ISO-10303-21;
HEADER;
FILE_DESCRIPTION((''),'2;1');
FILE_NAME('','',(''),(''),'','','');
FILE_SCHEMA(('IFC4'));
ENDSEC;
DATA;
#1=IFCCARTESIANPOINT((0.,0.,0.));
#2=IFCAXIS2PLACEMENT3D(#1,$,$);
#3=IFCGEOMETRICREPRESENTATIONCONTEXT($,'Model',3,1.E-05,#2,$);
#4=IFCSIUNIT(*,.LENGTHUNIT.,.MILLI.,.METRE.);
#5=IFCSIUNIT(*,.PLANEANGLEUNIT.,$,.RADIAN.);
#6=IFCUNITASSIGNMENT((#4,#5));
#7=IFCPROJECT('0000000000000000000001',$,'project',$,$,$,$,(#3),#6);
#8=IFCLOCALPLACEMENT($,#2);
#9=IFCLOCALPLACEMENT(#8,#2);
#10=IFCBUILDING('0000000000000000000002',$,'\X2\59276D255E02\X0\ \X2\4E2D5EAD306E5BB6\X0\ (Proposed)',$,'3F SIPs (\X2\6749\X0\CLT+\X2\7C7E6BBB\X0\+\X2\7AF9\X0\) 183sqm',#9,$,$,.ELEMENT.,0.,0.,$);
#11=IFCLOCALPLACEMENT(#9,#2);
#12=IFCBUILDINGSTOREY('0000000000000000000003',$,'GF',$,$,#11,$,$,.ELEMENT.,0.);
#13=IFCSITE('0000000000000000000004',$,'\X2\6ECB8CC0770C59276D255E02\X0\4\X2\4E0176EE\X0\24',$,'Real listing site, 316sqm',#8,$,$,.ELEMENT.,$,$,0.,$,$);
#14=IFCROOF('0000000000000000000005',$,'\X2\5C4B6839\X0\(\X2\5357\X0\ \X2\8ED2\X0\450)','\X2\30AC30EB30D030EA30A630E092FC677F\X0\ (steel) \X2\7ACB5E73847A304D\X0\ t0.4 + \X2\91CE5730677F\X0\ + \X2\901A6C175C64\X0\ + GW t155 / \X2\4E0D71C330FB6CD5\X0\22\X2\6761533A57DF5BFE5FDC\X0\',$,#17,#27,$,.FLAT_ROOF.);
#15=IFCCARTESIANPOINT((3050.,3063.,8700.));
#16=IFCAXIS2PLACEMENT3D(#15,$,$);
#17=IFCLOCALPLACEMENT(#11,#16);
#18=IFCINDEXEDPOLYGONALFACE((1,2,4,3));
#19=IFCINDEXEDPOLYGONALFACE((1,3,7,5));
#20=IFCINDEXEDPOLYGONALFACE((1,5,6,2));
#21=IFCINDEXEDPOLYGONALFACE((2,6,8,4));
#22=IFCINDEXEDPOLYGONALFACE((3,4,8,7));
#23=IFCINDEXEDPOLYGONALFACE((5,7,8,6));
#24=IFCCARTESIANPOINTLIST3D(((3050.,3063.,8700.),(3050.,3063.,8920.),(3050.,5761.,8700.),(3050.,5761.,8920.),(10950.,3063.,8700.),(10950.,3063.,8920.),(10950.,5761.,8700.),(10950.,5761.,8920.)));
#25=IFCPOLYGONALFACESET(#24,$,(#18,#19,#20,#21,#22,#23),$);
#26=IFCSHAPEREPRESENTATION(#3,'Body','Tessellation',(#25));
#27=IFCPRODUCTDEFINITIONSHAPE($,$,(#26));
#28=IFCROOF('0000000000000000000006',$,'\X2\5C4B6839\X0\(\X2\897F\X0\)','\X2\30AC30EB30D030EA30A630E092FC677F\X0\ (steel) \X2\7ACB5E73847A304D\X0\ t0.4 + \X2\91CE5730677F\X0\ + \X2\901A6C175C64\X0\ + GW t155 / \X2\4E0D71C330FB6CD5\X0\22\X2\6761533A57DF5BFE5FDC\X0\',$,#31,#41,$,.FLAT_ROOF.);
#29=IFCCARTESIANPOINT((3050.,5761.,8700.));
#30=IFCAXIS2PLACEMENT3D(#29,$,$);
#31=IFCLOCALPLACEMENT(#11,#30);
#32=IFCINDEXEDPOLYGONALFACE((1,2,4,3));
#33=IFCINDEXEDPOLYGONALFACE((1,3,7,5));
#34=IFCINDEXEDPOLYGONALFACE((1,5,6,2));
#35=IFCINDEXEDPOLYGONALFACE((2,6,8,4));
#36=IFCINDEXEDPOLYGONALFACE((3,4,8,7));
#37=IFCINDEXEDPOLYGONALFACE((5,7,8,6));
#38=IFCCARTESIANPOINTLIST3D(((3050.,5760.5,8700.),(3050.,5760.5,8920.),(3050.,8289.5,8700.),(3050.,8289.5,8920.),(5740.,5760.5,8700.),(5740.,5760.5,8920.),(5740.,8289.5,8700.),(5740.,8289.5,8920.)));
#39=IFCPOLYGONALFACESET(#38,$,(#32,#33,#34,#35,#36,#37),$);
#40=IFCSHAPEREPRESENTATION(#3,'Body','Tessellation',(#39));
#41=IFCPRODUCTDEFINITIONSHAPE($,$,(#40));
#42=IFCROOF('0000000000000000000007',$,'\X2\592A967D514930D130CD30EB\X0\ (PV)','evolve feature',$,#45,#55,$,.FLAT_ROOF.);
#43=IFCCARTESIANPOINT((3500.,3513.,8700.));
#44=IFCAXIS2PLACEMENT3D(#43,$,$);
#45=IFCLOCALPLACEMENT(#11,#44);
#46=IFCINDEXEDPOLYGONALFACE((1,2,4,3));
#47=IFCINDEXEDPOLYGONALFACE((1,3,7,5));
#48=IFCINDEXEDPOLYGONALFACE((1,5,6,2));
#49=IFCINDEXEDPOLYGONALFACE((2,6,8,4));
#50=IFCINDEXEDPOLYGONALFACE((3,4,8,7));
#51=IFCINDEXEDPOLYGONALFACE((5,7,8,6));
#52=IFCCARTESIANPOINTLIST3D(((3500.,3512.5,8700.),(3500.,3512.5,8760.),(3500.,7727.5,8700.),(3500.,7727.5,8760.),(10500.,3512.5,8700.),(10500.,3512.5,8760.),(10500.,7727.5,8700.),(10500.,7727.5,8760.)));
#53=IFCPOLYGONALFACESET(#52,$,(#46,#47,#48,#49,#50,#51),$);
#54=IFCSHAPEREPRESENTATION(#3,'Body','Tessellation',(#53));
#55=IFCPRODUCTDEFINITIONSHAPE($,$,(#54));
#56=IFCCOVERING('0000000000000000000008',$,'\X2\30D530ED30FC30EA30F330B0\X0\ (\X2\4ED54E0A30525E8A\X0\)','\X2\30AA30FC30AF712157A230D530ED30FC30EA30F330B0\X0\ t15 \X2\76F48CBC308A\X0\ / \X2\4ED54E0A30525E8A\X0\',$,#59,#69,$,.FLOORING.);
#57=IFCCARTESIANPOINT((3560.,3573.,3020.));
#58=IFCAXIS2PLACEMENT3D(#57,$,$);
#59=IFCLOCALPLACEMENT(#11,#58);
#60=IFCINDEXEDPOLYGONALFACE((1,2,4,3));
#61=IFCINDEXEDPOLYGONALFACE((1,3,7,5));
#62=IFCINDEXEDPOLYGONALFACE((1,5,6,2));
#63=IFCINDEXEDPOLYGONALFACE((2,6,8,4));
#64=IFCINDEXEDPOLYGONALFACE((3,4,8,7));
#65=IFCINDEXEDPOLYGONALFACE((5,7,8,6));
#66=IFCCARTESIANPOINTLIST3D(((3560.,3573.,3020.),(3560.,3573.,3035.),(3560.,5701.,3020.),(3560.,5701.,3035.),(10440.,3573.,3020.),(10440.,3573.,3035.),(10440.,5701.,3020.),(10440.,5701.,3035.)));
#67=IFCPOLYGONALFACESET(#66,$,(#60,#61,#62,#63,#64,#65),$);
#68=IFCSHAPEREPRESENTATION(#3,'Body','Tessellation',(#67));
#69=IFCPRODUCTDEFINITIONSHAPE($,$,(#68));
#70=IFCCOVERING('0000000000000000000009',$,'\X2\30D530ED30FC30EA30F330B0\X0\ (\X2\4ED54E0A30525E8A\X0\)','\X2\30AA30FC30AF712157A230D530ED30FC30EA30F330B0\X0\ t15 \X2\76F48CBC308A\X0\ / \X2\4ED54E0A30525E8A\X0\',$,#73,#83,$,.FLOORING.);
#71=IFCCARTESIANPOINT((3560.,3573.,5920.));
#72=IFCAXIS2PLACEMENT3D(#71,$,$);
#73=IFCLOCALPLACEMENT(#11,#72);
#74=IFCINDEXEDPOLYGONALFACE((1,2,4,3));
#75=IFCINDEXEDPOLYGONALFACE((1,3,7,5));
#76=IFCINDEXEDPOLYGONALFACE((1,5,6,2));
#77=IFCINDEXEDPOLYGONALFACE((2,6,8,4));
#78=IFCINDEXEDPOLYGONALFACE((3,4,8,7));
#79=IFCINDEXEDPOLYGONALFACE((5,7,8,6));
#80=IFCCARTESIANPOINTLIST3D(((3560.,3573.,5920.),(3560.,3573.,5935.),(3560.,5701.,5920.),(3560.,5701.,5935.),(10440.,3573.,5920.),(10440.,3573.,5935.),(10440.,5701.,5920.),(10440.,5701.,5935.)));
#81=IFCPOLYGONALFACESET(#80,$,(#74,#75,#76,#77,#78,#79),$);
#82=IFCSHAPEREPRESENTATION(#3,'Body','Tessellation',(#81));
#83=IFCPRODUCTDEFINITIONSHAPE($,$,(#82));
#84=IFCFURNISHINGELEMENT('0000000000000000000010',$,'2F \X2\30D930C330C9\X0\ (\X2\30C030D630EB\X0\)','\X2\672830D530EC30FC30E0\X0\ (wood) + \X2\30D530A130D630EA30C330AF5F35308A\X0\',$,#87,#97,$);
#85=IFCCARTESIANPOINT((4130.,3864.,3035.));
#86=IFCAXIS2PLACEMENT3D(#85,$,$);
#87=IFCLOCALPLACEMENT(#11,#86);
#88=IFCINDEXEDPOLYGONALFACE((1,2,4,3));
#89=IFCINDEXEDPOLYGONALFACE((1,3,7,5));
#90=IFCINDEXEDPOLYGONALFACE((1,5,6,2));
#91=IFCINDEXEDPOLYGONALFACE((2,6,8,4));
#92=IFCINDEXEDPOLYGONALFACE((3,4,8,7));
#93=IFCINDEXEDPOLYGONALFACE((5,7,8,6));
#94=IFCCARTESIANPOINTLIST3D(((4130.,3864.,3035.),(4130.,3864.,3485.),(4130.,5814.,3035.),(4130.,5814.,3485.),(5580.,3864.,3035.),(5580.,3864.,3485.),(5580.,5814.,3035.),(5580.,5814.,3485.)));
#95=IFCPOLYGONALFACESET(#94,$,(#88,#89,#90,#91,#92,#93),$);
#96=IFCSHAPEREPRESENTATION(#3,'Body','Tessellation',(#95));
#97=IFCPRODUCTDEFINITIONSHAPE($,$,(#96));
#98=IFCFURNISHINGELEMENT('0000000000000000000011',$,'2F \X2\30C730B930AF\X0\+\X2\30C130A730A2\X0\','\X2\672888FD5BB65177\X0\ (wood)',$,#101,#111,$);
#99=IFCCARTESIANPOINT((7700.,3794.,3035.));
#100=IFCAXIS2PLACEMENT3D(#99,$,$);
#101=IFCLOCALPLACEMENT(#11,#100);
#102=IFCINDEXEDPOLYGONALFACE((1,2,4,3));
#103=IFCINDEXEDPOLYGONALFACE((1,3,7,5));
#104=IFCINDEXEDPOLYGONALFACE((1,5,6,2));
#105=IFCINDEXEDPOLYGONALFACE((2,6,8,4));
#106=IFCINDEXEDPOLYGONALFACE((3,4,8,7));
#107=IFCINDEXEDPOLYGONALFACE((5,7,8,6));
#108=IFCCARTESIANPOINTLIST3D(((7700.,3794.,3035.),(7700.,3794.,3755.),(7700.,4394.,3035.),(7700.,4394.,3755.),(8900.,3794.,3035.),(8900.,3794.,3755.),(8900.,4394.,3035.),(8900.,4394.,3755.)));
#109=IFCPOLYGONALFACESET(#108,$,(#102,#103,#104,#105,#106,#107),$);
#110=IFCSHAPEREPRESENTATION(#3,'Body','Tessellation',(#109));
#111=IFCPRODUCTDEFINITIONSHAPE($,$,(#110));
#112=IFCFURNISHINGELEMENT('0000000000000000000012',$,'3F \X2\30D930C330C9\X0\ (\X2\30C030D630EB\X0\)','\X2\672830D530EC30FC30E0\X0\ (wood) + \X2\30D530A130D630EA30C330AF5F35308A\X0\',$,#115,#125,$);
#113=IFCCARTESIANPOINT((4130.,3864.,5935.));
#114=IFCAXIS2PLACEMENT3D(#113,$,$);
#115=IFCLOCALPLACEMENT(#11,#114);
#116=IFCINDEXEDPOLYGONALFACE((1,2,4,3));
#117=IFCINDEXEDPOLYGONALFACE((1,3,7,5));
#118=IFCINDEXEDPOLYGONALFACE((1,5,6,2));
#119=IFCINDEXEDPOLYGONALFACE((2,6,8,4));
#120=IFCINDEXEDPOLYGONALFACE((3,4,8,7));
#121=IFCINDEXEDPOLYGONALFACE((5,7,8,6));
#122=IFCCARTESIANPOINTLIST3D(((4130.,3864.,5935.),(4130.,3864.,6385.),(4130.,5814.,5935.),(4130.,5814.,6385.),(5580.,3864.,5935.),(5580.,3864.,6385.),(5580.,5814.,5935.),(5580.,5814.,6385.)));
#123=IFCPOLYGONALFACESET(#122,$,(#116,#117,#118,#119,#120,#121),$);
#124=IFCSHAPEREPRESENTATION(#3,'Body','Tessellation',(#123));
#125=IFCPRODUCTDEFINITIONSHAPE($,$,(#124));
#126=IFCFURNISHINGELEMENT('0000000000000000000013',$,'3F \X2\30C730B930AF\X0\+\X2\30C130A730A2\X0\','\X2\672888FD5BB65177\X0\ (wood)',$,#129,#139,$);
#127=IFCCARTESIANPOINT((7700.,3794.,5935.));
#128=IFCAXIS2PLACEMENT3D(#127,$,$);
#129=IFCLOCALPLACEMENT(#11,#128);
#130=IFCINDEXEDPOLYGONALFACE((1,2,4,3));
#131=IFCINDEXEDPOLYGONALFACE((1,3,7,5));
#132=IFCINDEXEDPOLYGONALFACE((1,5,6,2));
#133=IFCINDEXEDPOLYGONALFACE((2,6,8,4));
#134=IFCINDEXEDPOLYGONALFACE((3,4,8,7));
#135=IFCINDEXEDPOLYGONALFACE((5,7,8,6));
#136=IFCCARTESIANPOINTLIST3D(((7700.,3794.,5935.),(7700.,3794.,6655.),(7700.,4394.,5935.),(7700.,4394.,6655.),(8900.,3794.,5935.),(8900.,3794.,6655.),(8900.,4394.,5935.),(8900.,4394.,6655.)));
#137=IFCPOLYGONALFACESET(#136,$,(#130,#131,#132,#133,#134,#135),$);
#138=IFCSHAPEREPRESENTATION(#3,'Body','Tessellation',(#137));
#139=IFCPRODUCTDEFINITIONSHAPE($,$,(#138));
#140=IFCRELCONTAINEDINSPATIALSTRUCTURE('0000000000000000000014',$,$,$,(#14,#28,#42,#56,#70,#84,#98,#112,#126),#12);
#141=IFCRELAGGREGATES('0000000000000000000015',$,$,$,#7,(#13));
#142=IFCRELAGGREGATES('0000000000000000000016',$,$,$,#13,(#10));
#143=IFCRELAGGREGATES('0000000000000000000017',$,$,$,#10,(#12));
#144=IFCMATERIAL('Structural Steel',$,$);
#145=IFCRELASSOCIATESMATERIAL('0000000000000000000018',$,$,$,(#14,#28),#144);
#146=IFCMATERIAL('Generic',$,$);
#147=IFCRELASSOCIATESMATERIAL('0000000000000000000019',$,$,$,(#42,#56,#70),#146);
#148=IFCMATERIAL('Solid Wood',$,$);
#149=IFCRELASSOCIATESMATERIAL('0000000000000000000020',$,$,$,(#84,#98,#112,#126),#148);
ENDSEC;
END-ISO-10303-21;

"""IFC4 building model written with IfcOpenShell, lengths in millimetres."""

from ifc_helpers import new_model, si_unit, frame, frame_2d, origin, place, context, project, spatial, rectangle, extrude, material, element, save


model = new_model("IFC4")

# Units and contexts
model_context = context("Model", 3, precision=1e-05, world=origin())
ifc_project = project(units=[si_unit("LENGTHUNIT", "METRE", prefix="MILLI"), si_unit("PLANEANGLEUNIT", "RADIAN")], contexts=[model_context])

# Site, building, storey
site_placement = place(None, origin())
site = spatial("IfcSite", under=ifc_project, at=site_placement, Name="滋賀県大津市4丁目24", ObjectType="Real listing site, 316sqm", CompositionType="ELEMENT", RefElevation=0.0)
building_placement = place(site_placement, origin())
building = spatial("IfcBuilding", under=site, at=building_placement, Name="大津市 中庭の家 (Proposed)", ObjectType="3F SIPs (杉CLT+籾殻+竹) 183sqm", CompositionType="ELEMENT", ElevationOfRefHeight=0.0, ElevationOfTerrain=0.0)
storey_placement = place(building_placement, origin())
storey = spatial("IfcBuildingStorey", under=building, at=storey_placement, Name="GF", CompositionType="ELEMENT", Elevation=0.0)

# Shared definitions
ifc_material_1 = material(Name="Solid Wood")

# Roofs
ifc_material_2 = material(Name="Structural Steel")
roof_1_placement = place(storey_placement, frame((3050.0, 3063.0, 8700.0)))
element("IfcRoof", 1, at=roof_1_placement, inside=storey, material=ifc_material_2, Name="屋根(南 軒450)", Description="ガルバリウム鋼板 (steel) 立平葺き t0.4 + 野地板 + 通気層 + GW t155 / 不燃・法22条区域対応", PredefinedType="FLAT_ROOF", context=model_context, shape_type="SweptSolid", body=[
    extrude(rectangle(XDim=7900.0, YDim=2698.0, at=frame_2d((3950.0, 1349.0))), frame((3050.0, 3063.0, 8700.0)), (0.0, 0.0, 1.0), 220.0),
])
roof_2_placement = place(storey_placement, frame((3050.0, 5761.0, 8700.0)))
element("IfcRoof", 2, at=roof_2_placement, inside=storey, material=ifc_material_2, Name="屋根(西)", Description="ガルバリウム鋼板 (steel) 立平葺き t0.4 + 野地板 + 通気層 + GW t155 / 不燃・法22条区域対応", PredefinedType="FLAT_ROOF", context=model_context, shape_type="SweptSolid", body=[
    extrude(rectangle(XDim=2690.0, YDim=2529.0, at=frame_2d((1345.0, 1264.0))), frame((3050.0, 5761.0, 8700.0)), (0.0, 0.0, 1.0), 220.0),
])
ifc_material_3 = material(Name="Generic")
roof_3_placement = place(storey_placement, frame((3500.0, 3513.0, 8700.0)))
element("IfcRoof", 3, at=roof_3_placement, inside=storey, material=ifc_material_3, Name="太陽光パネル (PV)", Description="evolve feature", PredefinedType="FLAT_ROOF", context=model_context, shape_type="SweptSolid", body=[
    extrude(rectangle(XDim=7000.0, YDim=4215.0, at=frame_2d((3500.0, 2107.0))), frame((3500.0, 3513.0, 8700.0)), (0.0, 0.0, 1.0), 60.0),
])

# Coverings
covering_1_placement = place(storey_placement, frame((3560.0, 3573.0, 3020.0)))
element("IfcCovering", 4, at=covering_1_placement, inside=storey, material=ifc_material_3, Name="フローリング (仕上げ床)", Description="オーク無垢フローリング t15 直貼り / 仕上げ床", PredefinedType="FLOORING", context=model_context, shape_type="SweptSolid", body=[
    extrude(rectangle(XDim=6880.0, YDim=2128.0, at=frame_2d((3440.0, 1064.0))), frame((3560.0, 3573.0, 3020.0)), (0.0, 0.0, 1.0), 15.0),
])
covering_2_placement = place(storey_placement, frame((3560.0, 3573.0, 5920.0)))
element("IfcCovering", 5, at=covering_2_placement, inside=storey, material=ifc_material_3, Name="フローリング (仕上げ床)", Description="オーク無垢フローリング t15 直貼り / 仕上げ床", PredefinedType="FLOORING", context=model_context, shape_type="SweptSolid", body=[
    extrude(rectangle(XDim=6880.0, YDim=2128.0, at=frame_2d((3440.0, 1064.0))), frame((3560.0, 3573.0, 5920.0)), (0.0, 0.0, 1.0), 15.0),
])

# Furnishing elements
furnishing_1_placement = place(storey_placement, frame((4130.0, 3864.0, 3035.0)))
element("IfcFurnishingElement", 6, at=furnishing_1_placement, inside=storey, material=ifc_material_1, Name="2F ベッド (ダブル)", Description="木フレーム (wood) + ファブリック張り", context=model_context, shape_type="SweptSolid", body=[
    extrude(rectangle(XDim=1450.0, YDim=1950.0, at=frame_2d((725.0, 975.0))), frame((4130.0, 3864.0, 3035.0)), (0.0, 0.0, 1.0), 450.0),
])
furnishing_2_placement = place(storey_placement, frame((7700.0, 3794.0, 3035.0)))
element("IfcFurnishingElement", 7, at=furnishing_2_placement, inside=storey, material=ifc_material_1, Name="2F デスク+チェア", Description="木製家具 (wood)", context=model_context, shape_type="SweptSolid", body=[
    extrude(rectangle(XDim=1200.0, YDim=600.0, at=frame_2d((600.0, 300.0))), frame((7700.0, 3794.0, 3035.0)), (0.0, 0.0, 1.0), 720.0),
])
furnishing_3_placement = place(storey_placement, frame((4130.0, 3864.0, 5935.0)))
element("IfcFurnishingElement", 8, at=furnishing_3_placement, inside=storey, material=ifc_material_1, Name="3F ベッド (ダブル)", Description="木フレーム (wood) + ファブリック張り", context=model_context, shape_type="SweptSolid", body=[
    extrude(rectangle(XDim=1450.0, YDim=1950.0, at=frame_2d((725.0, 975.0))), frame((4130.0, 3864.0, 5935.0)), (0.0, 0.0, 1.0), 450.0),
])
furnishing_4_placement = place(storey_placement, frame((7700.0, 3794.0, 5935.0)))
element("IfcFurnishingElement", 9, at=furnishing_4_placement, inside=storey, material=ifc_material_1, Name="3F デスク+チェア", Description="木製家具 (wood)", context=model_context, shape_type="SweptSolid", body=[
    extrude(rectangle(XDim=1200.0, YDim=600.0, at=frame_2d((600.0, 300.0))), frame((7700.0, 3794.0, 5935.0)), (0.0, 0.0, 1.0), 720.0),
])

save(model, "model.ifc")
